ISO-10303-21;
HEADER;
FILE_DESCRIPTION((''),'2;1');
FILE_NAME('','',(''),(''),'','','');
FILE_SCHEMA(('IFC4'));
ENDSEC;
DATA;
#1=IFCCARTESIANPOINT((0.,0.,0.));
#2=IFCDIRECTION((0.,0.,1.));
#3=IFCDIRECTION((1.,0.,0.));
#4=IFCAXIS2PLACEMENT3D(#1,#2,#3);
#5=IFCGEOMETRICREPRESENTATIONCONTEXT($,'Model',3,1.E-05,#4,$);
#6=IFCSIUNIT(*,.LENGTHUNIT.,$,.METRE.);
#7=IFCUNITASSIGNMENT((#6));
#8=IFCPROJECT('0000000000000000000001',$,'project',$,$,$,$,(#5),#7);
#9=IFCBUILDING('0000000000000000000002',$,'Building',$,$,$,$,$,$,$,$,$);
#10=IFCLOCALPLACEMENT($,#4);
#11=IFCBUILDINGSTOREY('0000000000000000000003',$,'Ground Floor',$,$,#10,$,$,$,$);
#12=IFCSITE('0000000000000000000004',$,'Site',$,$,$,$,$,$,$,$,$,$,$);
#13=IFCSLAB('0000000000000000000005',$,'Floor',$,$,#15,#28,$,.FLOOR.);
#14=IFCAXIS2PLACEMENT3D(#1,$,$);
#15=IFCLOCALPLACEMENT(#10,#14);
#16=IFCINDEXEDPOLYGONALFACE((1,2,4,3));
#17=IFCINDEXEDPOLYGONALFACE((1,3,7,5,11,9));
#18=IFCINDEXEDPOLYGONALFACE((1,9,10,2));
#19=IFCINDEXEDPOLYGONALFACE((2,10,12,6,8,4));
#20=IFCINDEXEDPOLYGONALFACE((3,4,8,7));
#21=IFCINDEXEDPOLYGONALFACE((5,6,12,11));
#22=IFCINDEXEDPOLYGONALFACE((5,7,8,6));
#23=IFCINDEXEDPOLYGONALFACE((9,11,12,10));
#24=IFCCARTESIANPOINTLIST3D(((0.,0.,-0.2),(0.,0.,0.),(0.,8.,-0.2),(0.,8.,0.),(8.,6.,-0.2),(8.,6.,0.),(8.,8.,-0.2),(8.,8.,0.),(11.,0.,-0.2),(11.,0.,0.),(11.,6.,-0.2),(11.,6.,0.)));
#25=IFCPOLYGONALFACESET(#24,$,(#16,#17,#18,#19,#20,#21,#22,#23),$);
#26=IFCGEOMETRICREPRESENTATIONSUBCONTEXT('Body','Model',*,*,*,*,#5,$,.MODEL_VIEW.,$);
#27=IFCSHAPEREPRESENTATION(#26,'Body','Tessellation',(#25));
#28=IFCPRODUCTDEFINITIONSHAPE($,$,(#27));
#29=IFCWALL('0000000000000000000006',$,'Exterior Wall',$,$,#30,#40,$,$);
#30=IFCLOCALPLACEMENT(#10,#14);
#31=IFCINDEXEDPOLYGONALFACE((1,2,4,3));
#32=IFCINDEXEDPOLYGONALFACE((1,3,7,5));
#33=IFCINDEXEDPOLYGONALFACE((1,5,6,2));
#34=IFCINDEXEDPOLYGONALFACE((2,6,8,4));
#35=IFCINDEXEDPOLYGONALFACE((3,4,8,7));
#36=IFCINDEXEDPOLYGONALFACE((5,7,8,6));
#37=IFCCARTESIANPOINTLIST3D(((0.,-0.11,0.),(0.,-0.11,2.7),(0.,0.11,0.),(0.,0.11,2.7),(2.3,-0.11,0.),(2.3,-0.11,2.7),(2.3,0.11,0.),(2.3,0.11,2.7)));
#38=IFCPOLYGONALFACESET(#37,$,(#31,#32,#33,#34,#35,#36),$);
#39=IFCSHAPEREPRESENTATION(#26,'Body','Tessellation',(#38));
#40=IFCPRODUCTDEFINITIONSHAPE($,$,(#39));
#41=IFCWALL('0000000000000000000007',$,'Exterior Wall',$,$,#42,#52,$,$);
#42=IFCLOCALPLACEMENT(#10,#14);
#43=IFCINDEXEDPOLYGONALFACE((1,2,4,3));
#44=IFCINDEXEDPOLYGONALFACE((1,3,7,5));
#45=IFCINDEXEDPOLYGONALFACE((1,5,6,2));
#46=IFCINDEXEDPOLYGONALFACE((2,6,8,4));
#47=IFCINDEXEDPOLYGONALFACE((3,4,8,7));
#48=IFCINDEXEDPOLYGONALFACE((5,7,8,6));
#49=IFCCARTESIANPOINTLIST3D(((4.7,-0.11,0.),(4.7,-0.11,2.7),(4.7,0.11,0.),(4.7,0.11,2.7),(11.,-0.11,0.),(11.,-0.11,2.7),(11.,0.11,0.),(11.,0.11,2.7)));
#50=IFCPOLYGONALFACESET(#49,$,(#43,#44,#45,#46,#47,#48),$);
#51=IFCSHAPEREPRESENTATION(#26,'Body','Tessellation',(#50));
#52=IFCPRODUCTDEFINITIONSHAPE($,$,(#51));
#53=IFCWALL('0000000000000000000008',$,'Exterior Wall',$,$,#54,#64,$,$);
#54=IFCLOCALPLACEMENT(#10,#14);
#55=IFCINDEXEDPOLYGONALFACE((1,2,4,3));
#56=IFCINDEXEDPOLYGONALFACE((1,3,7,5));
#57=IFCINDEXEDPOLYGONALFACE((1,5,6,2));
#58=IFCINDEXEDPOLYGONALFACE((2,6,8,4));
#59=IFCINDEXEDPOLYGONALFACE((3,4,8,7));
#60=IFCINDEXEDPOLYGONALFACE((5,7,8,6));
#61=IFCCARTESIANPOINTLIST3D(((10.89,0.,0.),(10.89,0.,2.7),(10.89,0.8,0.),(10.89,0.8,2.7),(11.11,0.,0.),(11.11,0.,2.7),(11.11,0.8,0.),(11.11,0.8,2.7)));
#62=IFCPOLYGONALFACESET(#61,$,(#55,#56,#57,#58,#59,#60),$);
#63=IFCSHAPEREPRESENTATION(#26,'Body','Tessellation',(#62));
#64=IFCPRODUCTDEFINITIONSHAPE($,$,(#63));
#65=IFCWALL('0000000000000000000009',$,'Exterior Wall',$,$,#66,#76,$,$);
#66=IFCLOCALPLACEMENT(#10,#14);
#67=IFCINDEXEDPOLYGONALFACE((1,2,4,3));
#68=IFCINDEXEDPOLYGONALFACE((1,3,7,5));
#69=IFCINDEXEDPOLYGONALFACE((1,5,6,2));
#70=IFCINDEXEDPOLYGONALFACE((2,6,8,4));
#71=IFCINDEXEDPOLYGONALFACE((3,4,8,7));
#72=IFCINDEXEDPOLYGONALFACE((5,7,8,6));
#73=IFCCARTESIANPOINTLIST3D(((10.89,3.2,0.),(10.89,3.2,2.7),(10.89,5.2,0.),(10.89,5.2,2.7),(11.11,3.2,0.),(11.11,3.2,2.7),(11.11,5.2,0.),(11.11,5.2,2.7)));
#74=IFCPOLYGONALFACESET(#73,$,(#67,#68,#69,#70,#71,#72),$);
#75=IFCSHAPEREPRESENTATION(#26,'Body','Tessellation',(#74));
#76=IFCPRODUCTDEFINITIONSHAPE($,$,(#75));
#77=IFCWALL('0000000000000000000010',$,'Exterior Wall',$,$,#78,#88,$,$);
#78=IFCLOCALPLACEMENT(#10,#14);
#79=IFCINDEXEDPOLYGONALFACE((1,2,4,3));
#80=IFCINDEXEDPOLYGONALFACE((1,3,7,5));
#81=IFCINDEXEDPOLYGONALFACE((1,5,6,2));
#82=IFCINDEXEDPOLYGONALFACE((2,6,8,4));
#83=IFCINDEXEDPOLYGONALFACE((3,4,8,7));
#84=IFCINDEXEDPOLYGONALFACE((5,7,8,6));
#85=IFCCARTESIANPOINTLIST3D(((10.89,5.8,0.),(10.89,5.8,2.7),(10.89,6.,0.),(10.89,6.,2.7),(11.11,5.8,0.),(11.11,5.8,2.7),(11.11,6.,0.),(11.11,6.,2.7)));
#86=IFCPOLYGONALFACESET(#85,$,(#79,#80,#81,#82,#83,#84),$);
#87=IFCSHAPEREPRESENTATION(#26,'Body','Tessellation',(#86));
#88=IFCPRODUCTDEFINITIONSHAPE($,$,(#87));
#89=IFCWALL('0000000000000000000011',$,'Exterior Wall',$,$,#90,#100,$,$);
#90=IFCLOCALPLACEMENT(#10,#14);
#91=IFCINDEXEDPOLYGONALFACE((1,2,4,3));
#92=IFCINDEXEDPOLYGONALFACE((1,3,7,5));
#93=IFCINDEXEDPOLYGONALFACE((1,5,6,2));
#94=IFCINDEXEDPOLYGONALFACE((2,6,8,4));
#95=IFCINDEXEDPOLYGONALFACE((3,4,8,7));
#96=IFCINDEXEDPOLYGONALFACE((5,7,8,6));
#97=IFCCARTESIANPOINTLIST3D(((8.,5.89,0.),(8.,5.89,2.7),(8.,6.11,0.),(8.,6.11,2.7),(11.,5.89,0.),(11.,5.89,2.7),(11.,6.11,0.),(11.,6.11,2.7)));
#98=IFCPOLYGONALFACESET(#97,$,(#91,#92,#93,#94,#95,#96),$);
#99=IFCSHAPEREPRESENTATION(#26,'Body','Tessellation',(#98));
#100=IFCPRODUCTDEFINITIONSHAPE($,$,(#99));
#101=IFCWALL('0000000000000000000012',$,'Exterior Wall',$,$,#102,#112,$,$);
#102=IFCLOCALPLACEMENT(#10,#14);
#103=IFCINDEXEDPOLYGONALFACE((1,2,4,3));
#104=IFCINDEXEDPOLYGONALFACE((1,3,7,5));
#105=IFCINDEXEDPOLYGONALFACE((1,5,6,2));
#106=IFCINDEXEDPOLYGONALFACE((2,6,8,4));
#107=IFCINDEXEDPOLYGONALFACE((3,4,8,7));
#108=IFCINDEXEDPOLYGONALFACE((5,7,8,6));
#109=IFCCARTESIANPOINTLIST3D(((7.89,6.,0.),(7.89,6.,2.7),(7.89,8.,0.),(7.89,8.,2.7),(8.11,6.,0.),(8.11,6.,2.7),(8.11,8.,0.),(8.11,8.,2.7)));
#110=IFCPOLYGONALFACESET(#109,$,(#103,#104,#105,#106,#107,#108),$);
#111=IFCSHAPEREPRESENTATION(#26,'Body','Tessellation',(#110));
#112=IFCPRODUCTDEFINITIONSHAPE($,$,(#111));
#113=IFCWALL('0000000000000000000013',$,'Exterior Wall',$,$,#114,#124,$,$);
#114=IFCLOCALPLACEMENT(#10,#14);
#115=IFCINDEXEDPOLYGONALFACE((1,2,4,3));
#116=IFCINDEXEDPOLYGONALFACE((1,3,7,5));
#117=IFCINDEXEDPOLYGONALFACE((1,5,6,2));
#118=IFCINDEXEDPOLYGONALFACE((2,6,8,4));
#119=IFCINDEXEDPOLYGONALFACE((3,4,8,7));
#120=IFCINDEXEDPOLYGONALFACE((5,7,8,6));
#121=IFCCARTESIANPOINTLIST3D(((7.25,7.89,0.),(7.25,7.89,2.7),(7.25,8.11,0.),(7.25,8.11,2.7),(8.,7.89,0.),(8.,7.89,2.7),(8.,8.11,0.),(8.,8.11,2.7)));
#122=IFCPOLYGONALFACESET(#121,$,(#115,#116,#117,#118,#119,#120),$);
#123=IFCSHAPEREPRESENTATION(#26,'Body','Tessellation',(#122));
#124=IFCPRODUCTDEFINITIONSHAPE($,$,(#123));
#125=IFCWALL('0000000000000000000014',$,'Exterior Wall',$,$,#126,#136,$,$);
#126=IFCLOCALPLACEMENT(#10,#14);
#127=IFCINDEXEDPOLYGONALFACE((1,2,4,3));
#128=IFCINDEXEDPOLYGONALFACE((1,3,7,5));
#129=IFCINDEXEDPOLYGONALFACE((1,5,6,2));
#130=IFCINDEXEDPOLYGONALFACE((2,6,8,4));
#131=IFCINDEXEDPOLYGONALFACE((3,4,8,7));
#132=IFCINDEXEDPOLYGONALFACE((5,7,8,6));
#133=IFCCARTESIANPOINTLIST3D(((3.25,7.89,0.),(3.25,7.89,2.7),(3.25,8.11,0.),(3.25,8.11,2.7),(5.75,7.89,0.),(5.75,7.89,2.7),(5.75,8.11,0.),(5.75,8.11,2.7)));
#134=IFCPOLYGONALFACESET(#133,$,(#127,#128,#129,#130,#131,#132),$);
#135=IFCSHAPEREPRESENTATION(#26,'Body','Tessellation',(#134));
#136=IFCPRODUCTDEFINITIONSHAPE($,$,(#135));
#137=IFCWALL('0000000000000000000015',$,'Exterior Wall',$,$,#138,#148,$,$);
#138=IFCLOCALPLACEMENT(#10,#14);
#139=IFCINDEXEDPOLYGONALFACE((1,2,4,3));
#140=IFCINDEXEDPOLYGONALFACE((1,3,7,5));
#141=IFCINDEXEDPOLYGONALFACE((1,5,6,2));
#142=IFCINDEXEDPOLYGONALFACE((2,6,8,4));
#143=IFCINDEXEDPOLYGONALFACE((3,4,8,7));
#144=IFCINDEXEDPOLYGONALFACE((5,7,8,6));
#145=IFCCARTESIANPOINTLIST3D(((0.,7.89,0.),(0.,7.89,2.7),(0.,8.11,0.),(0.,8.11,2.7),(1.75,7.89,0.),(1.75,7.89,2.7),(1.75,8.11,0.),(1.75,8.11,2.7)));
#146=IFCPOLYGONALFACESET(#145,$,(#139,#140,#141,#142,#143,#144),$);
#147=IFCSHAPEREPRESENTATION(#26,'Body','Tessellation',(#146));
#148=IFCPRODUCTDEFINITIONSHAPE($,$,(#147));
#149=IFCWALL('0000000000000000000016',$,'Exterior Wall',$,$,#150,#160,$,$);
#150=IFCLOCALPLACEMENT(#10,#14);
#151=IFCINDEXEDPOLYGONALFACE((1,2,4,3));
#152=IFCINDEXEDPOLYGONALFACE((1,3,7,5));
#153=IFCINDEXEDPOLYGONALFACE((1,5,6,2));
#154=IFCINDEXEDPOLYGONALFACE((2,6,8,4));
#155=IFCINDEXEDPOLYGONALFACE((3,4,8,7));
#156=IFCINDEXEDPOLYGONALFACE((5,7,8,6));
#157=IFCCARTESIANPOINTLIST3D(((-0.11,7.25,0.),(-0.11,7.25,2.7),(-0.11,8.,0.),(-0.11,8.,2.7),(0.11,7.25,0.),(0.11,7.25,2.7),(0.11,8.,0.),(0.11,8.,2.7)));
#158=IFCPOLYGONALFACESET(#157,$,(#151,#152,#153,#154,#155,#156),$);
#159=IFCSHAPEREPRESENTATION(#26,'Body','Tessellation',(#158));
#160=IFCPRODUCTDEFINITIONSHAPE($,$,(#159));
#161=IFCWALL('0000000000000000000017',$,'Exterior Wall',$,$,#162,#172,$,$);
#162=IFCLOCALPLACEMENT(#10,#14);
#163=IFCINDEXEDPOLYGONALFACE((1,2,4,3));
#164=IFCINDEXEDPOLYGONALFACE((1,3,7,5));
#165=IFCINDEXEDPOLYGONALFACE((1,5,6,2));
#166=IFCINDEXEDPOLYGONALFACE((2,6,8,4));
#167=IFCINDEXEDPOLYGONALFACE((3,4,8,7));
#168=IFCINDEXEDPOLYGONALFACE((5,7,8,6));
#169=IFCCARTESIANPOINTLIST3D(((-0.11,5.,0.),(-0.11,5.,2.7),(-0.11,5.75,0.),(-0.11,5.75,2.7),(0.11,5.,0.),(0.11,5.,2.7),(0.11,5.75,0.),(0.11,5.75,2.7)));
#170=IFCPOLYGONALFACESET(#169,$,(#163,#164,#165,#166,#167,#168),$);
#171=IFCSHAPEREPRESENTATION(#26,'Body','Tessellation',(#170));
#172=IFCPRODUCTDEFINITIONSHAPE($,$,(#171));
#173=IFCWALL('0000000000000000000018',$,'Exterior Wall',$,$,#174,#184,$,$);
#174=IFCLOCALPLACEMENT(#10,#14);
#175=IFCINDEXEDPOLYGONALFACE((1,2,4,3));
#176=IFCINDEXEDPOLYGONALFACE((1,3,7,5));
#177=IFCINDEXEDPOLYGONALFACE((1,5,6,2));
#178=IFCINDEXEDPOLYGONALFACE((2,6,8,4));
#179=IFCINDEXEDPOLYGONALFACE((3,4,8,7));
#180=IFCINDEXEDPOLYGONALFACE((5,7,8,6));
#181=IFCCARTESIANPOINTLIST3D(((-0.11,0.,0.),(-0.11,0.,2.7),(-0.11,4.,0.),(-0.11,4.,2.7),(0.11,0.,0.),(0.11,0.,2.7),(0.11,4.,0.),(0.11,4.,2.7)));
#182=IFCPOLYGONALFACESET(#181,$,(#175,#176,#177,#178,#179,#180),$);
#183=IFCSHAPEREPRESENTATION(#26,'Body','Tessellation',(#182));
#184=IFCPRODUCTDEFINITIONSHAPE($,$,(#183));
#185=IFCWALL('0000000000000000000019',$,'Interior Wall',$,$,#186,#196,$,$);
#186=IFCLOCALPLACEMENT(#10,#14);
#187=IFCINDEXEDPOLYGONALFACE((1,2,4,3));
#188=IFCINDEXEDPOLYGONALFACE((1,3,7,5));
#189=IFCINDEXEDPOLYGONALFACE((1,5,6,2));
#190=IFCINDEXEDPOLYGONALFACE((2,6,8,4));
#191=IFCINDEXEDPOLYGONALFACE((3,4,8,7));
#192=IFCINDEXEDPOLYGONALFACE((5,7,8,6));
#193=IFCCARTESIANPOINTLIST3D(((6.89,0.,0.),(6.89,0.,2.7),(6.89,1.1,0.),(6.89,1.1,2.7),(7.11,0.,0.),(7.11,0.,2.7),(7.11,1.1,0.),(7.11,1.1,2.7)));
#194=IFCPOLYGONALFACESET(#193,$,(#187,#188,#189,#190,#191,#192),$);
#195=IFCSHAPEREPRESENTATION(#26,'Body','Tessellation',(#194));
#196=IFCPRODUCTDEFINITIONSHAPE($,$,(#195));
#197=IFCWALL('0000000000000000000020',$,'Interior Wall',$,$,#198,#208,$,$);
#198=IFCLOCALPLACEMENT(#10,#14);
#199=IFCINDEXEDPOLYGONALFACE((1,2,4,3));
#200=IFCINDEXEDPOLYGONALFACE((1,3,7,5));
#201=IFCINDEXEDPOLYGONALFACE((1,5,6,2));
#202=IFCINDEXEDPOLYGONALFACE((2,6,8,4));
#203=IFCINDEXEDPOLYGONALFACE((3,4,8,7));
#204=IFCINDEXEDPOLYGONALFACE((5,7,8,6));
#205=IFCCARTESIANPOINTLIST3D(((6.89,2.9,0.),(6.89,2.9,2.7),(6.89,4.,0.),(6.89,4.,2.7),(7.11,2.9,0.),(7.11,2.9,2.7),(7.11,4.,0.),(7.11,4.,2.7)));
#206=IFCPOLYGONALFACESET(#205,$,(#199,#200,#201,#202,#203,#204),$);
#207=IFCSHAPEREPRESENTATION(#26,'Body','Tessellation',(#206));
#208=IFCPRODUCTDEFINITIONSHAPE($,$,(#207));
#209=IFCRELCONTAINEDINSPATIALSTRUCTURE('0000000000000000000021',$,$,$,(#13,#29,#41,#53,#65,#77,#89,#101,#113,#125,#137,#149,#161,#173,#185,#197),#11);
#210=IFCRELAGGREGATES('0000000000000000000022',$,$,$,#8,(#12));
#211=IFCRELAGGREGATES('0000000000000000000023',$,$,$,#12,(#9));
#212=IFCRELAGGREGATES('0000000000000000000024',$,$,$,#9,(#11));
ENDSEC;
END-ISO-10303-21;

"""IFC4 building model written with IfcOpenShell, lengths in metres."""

from ifc_helpers import new_model, si_unit, frame, origin_with_axes, place, context, subcontext, project, spatial, indexed_curve, outline, extrude, element, save


model = new_model("IFC4")

# Units and contexts
model_context = context("Model", 3, precision=1e-05, world=origin_with_axes())
body_context = subcontext(model_context, "Body", "Model", "MODEL_VIEW")
ifc_project = project(units=[si_unit("LENGTHUNIT", "METRE")], contexts=[model_context])

# Site, building, storey
site = spatial("IfcSite", under=ifc_project, Name="Site")
building = spatial("IfcBuilding", under=site, Name="Building")
storey_placement = place(None, origin_with_axes())
storey = spatial("IfcBuildingStorey", under=building, at=storey_placement, Name="Ground Floor")

# Slab
slab_placement = place(storey_placement, frame((0.0, 0.0, -0.2), z_axis=(0.0, 0.0, 1.0), x_axis=(1.0, 0.0, 0.0)))
element("IfcSlab", 1, at=slab_placement, inside=storey, Name="Floor", PredefinedType="FLOOR", context=body_context, shape_type="SweptSolid", body=[
    extrude(outline(indexed_curve([(0.0, 0.0), (11.0, 0.0), (11.0, 6.0), (8.0, 6.0), (8.0, 8.0), (0.0, 8.0)])), None, (0.0, 0.0, 1.0), 0.2),
])

# Walls
wall_1_placement = place(storey_placement, origin_with_axes())
element("IfcWall", 2, at=wall_1_placement, inside=storey, Name="Exterior Wall", context=body_context, shape_type="SweptSolid", body=[
    extrude(outline(indexed_curve([(0.0, 0.0), (0.0, 0.22), (2.3, 0.22), (2.3, 0.0), (0.0, 0.0)], self_intersect=False)), frame((0.0, -0.11, 0.0), z_axis=(0.0, 0.0, 1.0), x_axis=(1.0, 0.0, 0.0)), (0.0, 0.0, 1.0), 2.7),
])
wall_2_placement = place(storey_placement, frame((4.7, 0.0, 0.0), z_axis=(0.0, 0.0, 1.0), x_axis=(1.0, 0.0, 0.0)))
element("IfcWall", 3, at=wall_2_placement, inside=storey, Name="Exterior Wall", context=body_context, shape_type="SweptSolid", body=[
    extrude(outline(indexed_curve([(0.0, 0.0), (0.0, 0.22), (6.3, 0.22), (6.3, 0.0), (0.0, 0.0)], self_intersect=False)), frame((0.0, -0.11, 0.0), z_axis=(0.0, 0.0, 1.0), x_axis=(1.0, 0.0, 0.0)), (0.0, 0.0, 1.0), 2.7),
])
wall_3_placement = place(storey_placement, frame((11.0, 0.0, 0.0), z_axis=(0.0, 0.0, 1.0), x_axis=(0.0, 1.0, 0.0)))
element("IfcWall", 4, at=wall_3_placement, inside=storey, Name="Exterior Wall", context=body_context, shape_type="SweptSolid", body=[
    extrude(outline(indexed_curve([(0.0, 0.0), (0.0, 0.22), (0.8, 0.22), (0.8, 0.0), (0.0, 0.0)], self_intersect=False)), frame((0.0, -0.11, 0.0), z_axis=(0.0, 0.0, 1.0), x_axis=(1.0, 0.0, 0.0)), (0.0, 0.0, 1.0), 2.7),
])
wall_4_placement = place(storey_placement, frame((11.0, 3.2, 0.0), z_axis=(0.0, 0.0, 1.0), x_axis=(0.0, 1.0, 0.0)))
element("IfcWall", 5, at=wall_4_placement, inside=storey, Name="Exterior Wall", context=body_context, shape_type="SweptSolid", body=[
    extrude(outline(indexed_curve([(0.0, 0.0), (0.0, 0.22), (2.0, 0.22), (2.0, 0.0), (0.0, 0.0)], self_intersect=False)), frame((0.0, -0.11, 0.0), z_axis=(0.0, 0.0, 1.0), x_axis=(1.0, 0.0, 0.0)), (0.0, 0.0, 1.0), 2.7),
])
wall_5_placement = place(storey_placement, frame((11.0, 5.8, 0.0), z_axis=(0.0, 0.0, 1.0), x_axis=(0.0, 1.0, 0.0)))
element("IfcWall", 6, at=wall_5_placement, inside=storey, Name="Exterior Wall", context=body_context, shape_type="SweptSolid", body=[
    extrude(outline(indexed_curve([(0.0, 0.0), (0.0, 0.22), (0.2, 0.22), (0.2, 0.0), (0.0, 0.0)], self_intersect=False)), frame((0.0, -0.11, 0.0), z_axis=(0.0, 0.0, 1.0), x_axis=(1.0, 0.0, 0.0)), (0.0, 0.0, 1.0), 2.7),
])
wall_6_placement = place(storey_placement, frame((11.0, 6.0, 0.0), z_axis=(0.0, 0.0, 1.0), x_axis=(-1.0, 0.0, 0.0)))
element("IfcWall", 7, at=wall_6_placement, inside=storey, Name="Exterior Wall", context=body_context, shape_type="SweptSolid", body=[
    extrude(outline(indexed_curve([(0.0, 0.0), (0.0, 0.22), (3.0, 0.22), (3.0, 0.0), (0.0, 0.0)], self_intersect=False)), frame((0.0, -0.11, 0.0), z_axis=(0.0, 0.0, 1.0), x_axis=(1.0, 0.0, 0.0)), (0.0, 0.0, 1.0), 2.7),
])
wall_7_placement = place(storey_placement, frame((8.0, 6.0, 0.0), z_axis=(0.0, 0.0, 1.0), x_axis=(0.0, 1.0, 0.0)))
element("IfcWall", 8, at=wall_7_placement, inside=storey, Name="Exterior Wall", context=body_context, shape_type="SweptSolid", body=[
    extrude(outline(indexed_curve([(0.0, 0.0), (0.0, 0.22), (2.0, 0.22), (2.0, 0.0), (0.0, 0.0)], self_intersect=False)), frame((0.0, -0.11, 0.0), z_axis=(0.0, 0.0, 1.0), x_axis=(1.0, 0.0, 0.0)), (0.0, 0.0, 1.0), 2.7),
])
wall_8_placement = place(storey_placement, frame((8.0, 8.0, 0.0), z_axis=(0.0, 0.0, 1.0), x_axis=(-1.0, 0.0, 0.0)))
element("IfcWall", 9, at=wall_8_placement, inside=storey, Name="Exterior Wall", context=body_context, shape_type="SweptSolid", body=[
    extrude(outline(indexed_curve([(0.0, 0.0), (0.0, 0.22), (0.75, 0.22), (0.75, 0.0), (0.0, 0.0)], self_intersect=False)), frame((0.0, -0.11, 0.0), z_axis=(0.0, 0.0, 1.0), x_axis=(1.0, 0.0, 0.0)), (0.0, 0.0, 1.0), 2.7),
])
wall_9_placement = place(storey_placement, frame((5.75, 8.0, 0.0), z_axis=(0.0, 0.0, 1.0), x_axis=(-1.0, 0.0, 0.0)))
element("IfcWall", 10, at=wall_9_placement, inside=storey, Name="Exterior Wall", context=body_context, shape_type="SweptSolid", body=[
    extrude(outline(indexed_curve([(0.0, 0.0), (0.0, 0.22), (2.5, 0.22), (2.5, 0.0), (0.0, 0.0)], self_intersect=False)), frame((0.0, -0.11, 0.0), z_axis=(0.0, 0.0, 1.0), x_axis=(1.0, 0.0, 0.0)), (0.0, 0.0, 1.0), 2.7),
])
wall_10_placement = place(storey_placement, frame((1.75, 8.0, 0.0), z_axis=(0.0, 0.0, 1.0), x_axis=(-1.0, 0.0, 0.0)))
element("IfcWall", 11, at=wall_10_placement, inside=storey, Name="Exterior Wall", context=body_context, shape_type="SweptSolid", body=[
    extrude(outline(indexed_curve([(0.0, 0.0), (0.0, 0.22), (1.75, 0.22), (1.75, 0.0), (0.0, 0.0)], self_intersect=False)), frame((0.0, -0.11, 0.0), z_axis=(0.0, 0.0, 1.0), x_axis=(1.0, 0.0, 0.0)), (0.0, 0.0, 1.0), 2.7),
])
for number, where, z_axis, x_axis, name in (
    (12, (0.0, 8.0, 0.0), (0.0, 0.0, 1.0), (0.0, -1.0, 0.0), "Exterior Wall"),
    (13, (0.0, 5.75, 0.0), (0.0, 0.0, 1.0), (0.0, -1.0, 0.0), "Exterior Wall"),
):
    element("IfcWall", number, at=place(storey_placement, frame(where, z_axis=z_axis, x_axis=x_axis)), inside=storey, Name=name, context=body_context, shape_type="SweptSolid", body=[
        extrude(outline(indexed_curve([(0.0, 0.0), (0.0, 0.22), (0.75, 0.22), (0.75, 0.0), (0.0, 0.0)], self_intersect=False)), frame((0.0, -0.11, 0.0), z_axis=(0.0, 0.0, 1.0), x_axis=(1.0, 0.0, 0.0)), (0.0, 0.0, 1.0), 2.7),
    ])
wall_11_placement = place(storey_placement, frame((0.0, 4.0, 0.0), z_axis=(0.0, 0.0, 1.0), x_axis=(0.0, -1.0, 0.0)))
element("IfcWall", 14, at=wall_11_placement, inside=storey, Name="Exterior Wall", context=body_context, shape_type="SweptSolid", body=[
    extrude(outline(indexed_curve([(0.0, 0.0), (0.0, 0.22), (4.0, 0.22), (4.0, 0.0), (0.0, 0.0)], self_intersect=False)), frame((0.0, -0.11, 0.0), z_axis=(0.0, 0.0, 1.0), x_axis=(1.0, 0.0, 0.0)), (0.0, 0.0, 1.0), 2.7),
])
for number, where, z_axis, x_axis, name in (
    (15, (7.0, 0.0, 0.0), (0.0, 0.0, 1.0), (0.0, 1.0, 0.0), "Interior Wall"),
    (16, (7.0, 2.9, 0.0), (0.0, 0.0, 1.0), (0.0, 1.0, 0.0), "Interior Wall"),
):
    element("IfcWall", number, at=place(storey_placement, frame(where, z_axis=z_axis, x_axis=x_axis)), inside=storey, Name=name, context=body_context, shape_type="SweptSolid", body=[
        extrude(outline(indexed_curve([(0.0, 0.0), (0.0, 0.22), (1.1, 0.22), (1.1, 0.0), (0.0, 0.0)], self_intersect=False)), frame((0.0, -0.11, 0.0), z_axis=(0.0, 0.0, 1.0), x_axis=(1.0, 0.0, 0.0)), (0.0, 0.0, 1.0), 2.7),
    ])

save(model, "model.ifc")
